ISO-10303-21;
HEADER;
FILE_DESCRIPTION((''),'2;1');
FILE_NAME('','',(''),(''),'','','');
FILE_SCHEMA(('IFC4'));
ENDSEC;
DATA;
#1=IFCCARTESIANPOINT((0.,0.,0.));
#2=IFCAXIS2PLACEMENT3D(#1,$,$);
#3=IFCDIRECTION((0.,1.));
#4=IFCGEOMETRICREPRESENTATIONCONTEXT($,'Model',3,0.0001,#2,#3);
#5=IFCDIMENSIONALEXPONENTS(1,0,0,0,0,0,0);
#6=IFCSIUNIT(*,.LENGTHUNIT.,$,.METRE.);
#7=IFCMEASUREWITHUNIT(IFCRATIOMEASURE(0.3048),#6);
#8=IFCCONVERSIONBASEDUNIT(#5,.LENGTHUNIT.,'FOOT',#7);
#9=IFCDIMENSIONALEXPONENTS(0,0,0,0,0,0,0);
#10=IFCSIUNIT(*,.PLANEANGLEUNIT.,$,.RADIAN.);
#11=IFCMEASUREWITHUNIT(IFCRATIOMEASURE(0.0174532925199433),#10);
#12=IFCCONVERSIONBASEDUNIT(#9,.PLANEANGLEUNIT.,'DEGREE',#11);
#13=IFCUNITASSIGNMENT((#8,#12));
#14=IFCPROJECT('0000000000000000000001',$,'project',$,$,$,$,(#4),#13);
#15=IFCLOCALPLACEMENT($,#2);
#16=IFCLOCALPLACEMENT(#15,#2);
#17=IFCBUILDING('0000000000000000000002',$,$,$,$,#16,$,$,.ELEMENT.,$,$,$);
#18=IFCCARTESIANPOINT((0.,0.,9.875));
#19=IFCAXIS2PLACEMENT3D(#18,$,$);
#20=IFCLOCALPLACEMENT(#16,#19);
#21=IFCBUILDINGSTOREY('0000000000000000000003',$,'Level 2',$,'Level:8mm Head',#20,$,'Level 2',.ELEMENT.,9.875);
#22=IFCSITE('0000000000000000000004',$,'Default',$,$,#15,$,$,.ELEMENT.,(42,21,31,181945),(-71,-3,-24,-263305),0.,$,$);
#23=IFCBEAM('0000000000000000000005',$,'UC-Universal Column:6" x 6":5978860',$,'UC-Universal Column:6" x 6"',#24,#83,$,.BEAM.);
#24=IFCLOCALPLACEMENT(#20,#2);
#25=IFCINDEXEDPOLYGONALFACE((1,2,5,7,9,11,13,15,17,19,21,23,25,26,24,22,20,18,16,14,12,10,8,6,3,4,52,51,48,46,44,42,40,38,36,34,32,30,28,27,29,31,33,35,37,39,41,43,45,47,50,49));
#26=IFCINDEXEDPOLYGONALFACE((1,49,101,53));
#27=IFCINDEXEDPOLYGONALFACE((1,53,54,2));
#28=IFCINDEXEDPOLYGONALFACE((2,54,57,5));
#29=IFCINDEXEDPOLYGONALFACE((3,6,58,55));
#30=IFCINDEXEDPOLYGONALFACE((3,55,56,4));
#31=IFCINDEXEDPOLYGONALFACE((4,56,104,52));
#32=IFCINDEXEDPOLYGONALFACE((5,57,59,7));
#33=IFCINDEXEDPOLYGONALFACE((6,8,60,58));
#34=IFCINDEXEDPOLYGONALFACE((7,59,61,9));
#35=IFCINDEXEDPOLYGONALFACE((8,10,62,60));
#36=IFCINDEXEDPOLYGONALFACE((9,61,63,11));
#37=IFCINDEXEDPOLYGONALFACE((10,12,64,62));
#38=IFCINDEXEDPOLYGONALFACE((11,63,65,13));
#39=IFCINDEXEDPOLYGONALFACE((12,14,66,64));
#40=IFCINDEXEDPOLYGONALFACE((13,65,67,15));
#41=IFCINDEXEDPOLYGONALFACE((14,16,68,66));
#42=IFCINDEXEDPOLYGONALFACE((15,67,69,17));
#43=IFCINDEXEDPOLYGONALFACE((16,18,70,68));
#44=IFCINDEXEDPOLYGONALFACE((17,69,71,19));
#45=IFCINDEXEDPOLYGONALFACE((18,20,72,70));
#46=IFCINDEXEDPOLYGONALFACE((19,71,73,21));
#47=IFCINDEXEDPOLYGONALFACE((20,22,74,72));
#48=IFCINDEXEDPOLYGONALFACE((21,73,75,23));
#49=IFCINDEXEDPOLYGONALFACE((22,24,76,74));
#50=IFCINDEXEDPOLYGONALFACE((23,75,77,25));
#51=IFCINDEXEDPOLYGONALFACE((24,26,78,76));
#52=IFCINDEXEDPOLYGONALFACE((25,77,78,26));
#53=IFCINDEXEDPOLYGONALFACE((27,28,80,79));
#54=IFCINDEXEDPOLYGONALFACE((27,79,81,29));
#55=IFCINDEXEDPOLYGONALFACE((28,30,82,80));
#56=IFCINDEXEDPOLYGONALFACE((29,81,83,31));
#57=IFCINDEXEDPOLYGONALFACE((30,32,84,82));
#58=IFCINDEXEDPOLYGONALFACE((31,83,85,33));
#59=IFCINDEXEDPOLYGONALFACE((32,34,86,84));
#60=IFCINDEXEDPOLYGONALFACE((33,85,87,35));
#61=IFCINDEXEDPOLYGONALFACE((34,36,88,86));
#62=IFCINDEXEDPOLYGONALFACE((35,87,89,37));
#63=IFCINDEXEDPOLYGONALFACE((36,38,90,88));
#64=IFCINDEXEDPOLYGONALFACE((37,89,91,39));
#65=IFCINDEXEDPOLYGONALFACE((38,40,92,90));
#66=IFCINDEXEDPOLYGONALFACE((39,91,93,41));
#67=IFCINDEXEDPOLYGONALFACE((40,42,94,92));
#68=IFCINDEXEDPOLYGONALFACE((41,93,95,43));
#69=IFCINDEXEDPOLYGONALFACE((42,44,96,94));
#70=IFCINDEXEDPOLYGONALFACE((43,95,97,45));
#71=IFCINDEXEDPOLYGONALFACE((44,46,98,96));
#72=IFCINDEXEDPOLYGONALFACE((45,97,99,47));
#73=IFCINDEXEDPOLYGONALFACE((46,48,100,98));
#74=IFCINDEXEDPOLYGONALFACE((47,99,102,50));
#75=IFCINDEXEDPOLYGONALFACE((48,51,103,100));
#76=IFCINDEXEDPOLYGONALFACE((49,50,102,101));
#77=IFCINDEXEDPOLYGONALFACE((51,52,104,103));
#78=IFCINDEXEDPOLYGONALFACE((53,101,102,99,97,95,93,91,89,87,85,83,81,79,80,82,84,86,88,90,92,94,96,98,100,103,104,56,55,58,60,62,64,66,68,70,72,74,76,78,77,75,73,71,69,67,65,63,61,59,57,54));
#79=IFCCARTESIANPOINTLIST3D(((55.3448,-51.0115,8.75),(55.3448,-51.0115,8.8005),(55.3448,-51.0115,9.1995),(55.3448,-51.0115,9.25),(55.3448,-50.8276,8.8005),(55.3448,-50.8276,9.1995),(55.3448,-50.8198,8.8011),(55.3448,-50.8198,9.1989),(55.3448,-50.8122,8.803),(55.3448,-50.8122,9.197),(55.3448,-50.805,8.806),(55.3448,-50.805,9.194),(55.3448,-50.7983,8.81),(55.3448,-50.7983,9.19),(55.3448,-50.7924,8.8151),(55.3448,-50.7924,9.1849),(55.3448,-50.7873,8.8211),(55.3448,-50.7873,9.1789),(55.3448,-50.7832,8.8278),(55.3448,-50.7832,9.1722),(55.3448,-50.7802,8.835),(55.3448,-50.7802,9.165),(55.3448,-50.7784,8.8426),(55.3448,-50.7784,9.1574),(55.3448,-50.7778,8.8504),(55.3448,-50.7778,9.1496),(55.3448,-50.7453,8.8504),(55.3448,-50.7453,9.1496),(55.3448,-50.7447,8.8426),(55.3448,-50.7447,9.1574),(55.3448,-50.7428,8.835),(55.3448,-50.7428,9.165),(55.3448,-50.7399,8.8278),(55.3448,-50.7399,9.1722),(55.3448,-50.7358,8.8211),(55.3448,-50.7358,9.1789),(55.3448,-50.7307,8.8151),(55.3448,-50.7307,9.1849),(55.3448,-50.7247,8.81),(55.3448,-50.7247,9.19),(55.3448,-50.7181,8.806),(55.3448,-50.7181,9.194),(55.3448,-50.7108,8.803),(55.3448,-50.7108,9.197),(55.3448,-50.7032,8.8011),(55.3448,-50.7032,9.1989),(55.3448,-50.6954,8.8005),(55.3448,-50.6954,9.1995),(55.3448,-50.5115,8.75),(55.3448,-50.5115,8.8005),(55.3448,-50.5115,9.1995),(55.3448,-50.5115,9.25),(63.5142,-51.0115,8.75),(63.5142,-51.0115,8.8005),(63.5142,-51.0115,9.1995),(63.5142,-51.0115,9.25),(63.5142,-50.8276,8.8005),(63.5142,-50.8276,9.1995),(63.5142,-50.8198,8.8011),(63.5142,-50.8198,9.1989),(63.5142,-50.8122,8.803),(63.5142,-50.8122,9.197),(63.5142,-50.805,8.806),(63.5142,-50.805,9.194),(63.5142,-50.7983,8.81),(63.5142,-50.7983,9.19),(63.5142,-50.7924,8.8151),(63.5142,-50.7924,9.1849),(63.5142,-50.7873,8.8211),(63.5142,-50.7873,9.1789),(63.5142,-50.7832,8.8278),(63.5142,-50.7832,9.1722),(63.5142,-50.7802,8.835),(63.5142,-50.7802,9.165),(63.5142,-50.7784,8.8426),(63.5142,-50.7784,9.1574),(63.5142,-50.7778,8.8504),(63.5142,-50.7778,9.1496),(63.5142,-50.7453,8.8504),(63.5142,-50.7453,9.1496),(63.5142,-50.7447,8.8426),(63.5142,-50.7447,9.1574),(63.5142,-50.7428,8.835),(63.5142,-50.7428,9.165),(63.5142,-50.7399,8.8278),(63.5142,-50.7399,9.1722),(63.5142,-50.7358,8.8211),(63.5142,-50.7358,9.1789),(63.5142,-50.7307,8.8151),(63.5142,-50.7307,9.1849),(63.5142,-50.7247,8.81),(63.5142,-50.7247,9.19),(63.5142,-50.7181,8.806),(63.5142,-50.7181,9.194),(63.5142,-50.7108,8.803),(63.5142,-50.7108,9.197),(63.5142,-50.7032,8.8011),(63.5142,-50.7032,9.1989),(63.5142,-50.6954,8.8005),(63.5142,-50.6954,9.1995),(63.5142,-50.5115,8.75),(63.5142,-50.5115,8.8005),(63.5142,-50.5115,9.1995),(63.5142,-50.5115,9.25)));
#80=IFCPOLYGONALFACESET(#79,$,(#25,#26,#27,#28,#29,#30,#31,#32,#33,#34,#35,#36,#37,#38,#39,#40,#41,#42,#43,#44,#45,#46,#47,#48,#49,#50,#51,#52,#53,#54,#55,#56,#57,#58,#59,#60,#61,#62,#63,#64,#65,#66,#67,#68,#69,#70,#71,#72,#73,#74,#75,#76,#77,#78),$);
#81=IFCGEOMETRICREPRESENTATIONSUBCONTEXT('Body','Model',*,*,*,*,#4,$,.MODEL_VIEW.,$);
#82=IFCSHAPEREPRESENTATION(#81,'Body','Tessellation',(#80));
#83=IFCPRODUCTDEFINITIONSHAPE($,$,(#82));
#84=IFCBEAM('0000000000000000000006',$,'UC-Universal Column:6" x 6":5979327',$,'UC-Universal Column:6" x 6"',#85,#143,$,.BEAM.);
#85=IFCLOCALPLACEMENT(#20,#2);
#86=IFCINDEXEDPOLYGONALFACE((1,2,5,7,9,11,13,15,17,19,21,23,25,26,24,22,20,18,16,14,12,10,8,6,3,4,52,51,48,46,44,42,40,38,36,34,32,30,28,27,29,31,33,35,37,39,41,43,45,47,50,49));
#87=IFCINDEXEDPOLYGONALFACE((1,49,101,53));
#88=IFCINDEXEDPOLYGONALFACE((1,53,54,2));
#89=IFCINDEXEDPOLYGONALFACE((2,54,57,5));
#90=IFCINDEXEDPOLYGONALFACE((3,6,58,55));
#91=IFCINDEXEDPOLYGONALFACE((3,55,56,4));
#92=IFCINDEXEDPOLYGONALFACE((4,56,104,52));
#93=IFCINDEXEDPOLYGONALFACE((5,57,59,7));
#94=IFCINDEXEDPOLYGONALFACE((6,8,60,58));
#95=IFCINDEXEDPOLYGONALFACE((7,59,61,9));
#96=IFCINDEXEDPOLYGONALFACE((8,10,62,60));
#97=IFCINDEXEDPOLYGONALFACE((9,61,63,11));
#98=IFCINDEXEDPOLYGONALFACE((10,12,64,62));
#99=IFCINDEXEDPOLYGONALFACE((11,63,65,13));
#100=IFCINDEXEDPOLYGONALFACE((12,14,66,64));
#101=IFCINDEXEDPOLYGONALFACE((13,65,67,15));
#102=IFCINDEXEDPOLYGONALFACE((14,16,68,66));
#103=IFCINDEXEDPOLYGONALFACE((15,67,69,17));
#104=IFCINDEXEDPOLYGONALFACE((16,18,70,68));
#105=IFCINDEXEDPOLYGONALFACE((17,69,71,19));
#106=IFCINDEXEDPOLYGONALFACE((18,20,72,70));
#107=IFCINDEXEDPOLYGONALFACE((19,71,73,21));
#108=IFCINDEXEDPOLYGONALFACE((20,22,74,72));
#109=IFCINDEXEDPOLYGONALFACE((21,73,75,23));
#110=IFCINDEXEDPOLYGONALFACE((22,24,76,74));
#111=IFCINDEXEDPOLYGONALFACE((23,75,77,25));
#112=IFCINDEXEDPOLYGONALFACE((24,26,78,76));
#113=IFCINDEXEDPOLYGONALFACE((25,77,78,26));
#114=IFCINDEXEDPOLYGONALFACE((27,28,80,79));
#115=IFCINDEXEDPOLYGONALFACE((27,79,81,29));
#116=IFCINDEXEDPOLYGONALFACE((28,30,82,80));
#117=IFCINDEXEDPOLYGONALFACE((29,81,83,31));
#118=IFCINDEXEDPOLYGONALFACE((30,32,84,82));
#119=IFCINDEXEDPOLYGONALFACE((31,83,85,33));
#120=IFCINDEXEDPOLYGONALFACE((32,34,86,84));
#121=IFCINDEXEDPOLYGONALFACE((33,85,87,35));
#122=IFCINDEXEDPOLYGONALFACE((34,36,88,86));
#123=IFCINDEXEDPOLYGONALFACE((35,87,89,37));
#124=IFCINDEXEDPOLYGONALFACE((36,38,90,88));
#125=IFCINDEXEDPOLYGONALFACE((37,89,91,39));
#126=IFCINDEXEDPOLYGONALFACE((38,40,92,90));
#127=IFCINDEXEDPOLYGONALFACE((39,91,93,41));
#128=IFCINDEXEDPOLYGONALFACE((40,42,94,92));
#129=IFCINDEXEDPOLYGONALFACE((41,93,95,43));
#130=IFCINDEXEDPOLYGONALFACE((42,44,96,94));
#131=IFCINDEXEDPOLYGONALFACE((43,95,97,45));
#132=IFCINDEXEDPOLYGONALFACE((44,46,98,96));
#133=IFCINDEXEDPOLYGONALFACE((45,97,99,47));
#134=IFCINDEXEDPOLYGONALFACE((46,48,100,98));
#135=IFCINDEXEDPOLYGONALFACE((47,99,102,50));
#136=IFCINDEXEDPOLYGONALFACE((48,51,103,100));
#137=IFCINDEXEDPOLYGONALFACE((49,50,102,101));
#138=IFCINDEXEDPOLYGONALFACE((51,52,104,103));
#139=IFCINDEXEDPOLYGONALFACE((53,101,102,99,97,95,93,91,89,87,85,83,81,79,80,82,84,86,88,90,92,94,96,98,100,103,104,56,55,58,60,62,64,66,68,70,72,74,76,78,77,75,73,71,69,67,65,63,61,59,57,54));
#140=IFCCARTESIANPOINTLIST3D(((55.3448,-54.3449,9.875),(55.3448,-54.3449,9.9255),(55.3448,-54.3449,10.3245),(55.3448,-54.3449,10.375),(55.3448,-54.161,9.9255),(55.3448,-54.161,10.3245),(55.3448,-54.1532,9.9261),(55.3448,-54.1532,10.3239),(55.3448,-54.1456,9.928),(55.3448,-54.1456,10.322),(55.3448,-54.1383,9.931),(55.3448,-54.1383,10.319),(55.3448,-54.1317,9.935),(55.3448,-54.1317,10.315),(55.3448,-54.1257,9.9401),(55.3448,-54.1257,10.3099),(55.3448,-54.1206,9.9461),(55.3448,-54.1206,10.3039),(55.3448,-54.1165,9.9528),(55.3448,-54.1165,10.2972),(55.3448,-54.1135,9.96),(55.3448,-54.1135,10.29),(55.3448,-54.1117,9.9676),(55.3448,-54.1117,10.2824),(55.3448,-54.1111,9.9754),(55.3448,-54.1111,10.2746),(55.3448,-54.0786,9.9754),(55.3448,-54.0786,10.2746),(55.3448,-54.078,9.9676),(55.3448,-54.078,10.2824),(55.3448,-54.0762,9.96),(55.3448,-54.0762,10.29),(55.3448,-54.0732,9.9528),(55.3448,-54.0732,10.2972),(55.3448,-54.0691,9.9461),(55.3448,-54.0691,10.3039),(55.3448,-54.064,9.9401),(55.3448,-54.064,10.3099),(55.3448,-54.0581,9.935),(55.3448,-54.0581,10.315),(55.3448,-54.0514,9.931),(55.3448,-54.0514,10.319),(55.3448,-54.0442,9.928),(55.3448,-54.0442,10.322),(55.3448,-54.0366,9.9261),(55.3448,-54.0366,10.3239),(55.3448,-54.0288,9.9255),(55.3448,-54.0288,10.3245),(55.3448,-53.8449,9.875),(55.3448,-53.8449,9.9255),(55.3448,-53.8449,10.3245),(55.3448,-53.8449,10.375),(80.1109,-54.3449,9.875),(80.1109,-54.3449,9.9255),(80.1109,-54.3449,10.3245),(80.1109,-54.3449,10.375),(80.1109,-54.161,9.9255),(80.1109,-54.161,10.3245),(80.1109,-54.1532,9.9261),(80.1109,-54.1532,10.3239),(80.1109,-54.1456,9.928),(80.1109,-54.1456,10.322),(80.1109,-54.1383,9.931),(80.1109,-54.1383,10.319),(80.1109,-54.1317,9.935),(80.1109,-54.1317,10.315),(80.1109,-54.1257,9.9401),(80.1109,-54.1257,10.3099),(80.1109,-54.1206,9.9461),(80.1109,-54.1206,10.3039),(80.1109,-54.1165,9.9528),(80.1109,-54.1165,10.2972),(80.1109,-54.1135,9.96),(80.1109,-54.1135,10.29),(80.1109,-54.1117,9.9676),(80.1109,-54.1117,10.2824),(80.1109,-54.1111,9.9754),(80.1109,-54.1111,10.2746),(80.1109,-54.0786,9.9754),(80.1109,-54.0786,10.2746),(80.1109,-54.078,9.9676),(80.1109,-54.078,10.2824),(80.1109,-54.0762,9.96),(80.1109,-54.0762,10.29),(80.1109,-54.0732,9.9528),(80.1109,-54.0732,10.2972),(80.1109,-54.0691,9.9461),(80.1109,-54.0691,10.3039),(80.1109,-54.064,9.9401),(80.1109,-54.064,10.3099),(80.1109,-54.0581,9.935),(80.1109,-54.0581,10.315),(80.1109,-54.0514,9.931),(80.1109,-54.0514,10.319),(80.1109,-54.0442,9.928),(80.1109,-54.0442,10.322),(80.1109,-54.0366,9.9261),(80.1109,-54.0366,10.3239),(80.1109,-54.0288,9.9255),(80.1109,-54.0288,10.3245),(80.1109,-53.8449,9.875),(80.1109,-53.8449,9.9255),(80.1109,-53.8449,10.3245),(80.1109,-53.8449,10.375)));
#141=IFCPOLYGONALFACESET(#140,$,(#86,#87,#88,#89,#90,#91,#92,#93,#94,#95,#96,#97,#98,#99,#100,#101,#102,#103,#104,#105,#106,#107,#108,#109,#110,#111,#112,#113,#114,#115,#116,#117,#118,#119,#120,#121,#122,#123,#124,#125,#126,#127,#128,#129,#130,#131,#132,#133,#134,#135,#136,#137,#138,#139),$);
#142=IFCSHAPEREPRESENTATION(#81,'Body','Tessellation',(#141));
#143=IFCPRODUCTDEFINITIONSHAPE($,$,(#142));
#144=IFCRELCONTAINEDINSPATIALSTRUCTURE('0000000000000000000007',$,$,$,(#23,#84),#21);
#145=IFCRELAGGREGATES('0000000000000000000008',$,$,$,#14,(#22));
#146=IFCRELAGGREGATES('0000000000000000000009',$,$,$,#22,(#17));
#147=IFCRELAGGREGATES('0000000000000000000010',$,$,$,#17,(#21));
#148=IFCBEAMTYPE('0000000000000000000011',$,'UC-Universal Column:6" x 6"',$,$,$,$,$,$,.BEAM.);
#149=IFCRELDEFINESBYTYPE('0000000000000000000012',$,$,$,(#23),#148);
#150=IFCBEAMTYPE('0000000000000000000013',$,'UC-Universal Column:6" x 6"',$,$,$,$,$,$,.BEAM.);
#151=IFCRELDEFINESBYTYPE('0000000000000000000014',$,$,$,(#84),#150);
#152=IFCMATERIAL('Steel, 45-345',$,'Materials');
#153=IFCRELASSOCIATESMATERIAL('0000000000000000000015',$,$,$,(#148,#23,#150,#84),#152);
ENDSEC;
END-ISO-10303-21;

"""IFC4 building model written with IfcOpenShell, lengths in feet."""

from ifc_helpers import new_model, entity, si_unit, converted_unit, direction, frame, origin, place, context, subcontext, project, spatial, indexed_curve, outline, extrude, source, transform, mapped, material, type_object, type_shapes, element, save


model = new_model("IFC4")

# Units and contexts
model_context = context("Model", 3, precision=0.0001, world=origin(), true_north=direction((0.0, 1.0)))
body_context = subcontext(model_context, "Body", "Model", "MODEL_VIEW")
ifc_project = project(units=[converted_unit("LENGTHUNIT", "FOOT", entity("IfcRatioMeasure", 0.3048), si_unit("LENGTHUNIT", "METRE"), dimensions=[1, 0, 0, 0, 0, 0, 0]), converted_unit("PLANEANGLEUNIT", "DEGREE", entity("IfcRatioMeasure", 0.0174532925199433), si_unit("PLANEANGLEUNIT", "RADIAN"), dimensions=[0, 0, 0, 0, 0, 0, 0])], contexts=[model_context])

# Site, building, storey
site_placement = place(None, origin())
site = spatial("IfcSite", under=ifc_project, at=site_placement, Name="Default", CompositionType="ELEMENT", RefLatitude=(42, 21, 31, 181945), RefLongitude=(-71, -3, -24, -263305), RefElevation=0.0)
building_placement = place(site_placement, origin())
building = spatial("IfcBuilding", under=site, at=building_placement, CompositionType="ELEMENT")
storey_placement = place(building_placement, frame((0.0, 0.0, 9.875)))
storey = spatial("IfcBuildingStorey", under=building, at=storey_placement, Name="Level 2", ObjectType="Level:8mm Head", LongName="Level 2", CompositionType="ELEMENT", Elevation=9.875)

# Beams
ifc_material_1 = material(Name="Steel, 45-345", Category="Materials")
beam_type_1 = type_object("IfcBeamType", Name="UC-Universal Column:6\" x 6\"", PredefinedType="BEAM", material=ifc_material_1)
shared_shape_1 = source(origin(), body_context, "Body", "SweptSolid", [
    extrude(outline(indexed_curve([(-0.25, -0.25), (-0.1995, -0.25), (-0.1995, -0.0661), (-0.1989, -0.0583), (-0.197, -0.0507), (-0.194, -0.0435), (-0.19, -0.0368), (-0.1849, -0.0308), (-0.1789, -0.0258), (-0.1722, -0.0217), (-0.165, -0.0187), (-0.1574, -0.0169), (-0.1496, -0.0162), (0.1496, -0.0162), (0.1574, -0.0169), (0.165, -0.0187), (0.1722, -0.0217), (0.1789, -0.0258), (0.1849, -0.0308), (0.19, -0.0368), (0.194, -0.0435), (0.197, -0.0507), (0.1989, -0.0583), (0.1995, -0.0661), (0.1995, -0.25), (0.25, -0.25), (0.25, 0.25), (0.1995, 0.25), (0.1995, 0.0661), (0.1989, 0.0583), (0.197, 0.0507), (0.194, 0.0435), (0.19, 0.0368), (0.1849, 0.0308), (0.1789, 0.0258), (0.1722, 0.0217), (0.165, 0.0187), (0.1574, 0.0169), (0.1496, 0.0162), (-0.1496, 0.0162), (-0.1574, 0.0169), (-0.165, 0.0187), (-0.1722, 0.0217), (-0.1789, 0.0258), (-0.1849, 0.0308), (-0.19, 0.0368), (-0.194, 0.0435), (-0.197, 0.0507), (-0.1989, 0.0583), (-0.1995, 0.0661), (-0.1995, 0.25), (-0.25, 0.25), (-0.25, -0.25)], self_intersect=False)), frame((-17.0237, 0.0, 0.0), z_axis=(1.0, 0.0, 0.0), x_axis=(0.0, 0.0, -1.0)), (0.0, 0.0, 1.0), 8.1694),
])
type_shapes(beam_type_1, [shared_shape_1])
beam_1_placement = place(storey_placement, frame((72.3685, -50.7615, 9.0)))
element("IfcBeam", 1, at=beam_1_placement, inside=storey, type_object=beam_type_1, material=ifc_material_1, Name="UC-Universal Column:6\" x 6\":5978860", ObjectType="UC-Universal Column:6\" x 6\"", PredefinedType="BEAM", context=body_context, shape_type="MappedRepresentation", body=[
    mapped(shared_shape_1, transform((0.0, 0.0, 0.0), scale=1.0)),
])
beam_type_2 = type_object("IfcBeamType", Name="UC-Universal Column:6\" x 6\"", PredefinedType="BEAM", material=ifc_material_1)
shared_shape_2 = source(origin(), body_context, "Body", "SweptSolid", [
    extrude(outline(indexed_curve([(-0.25, -0.25), (-0.1995, -0.25), (-0.1995, -0.0661), (-0.1989, -0.0583), (-0.197, -0.0507), (-0.194, -0.0435), (-0.19, -0.0368), (-0.1849, -0.0308), (-0.1789, -0.0258), (-0.1722, -0.0217), (-0.165, -0.0187), (-0.1574, -0.0169), (-0.1496, -0.0162), (0.1496, -0.0162), (0.1574, -0.0169), (0.165, -0.0187), (0.1722, -0.0217), (0.1789, -0.0258), (0.1849, -0.0308), (0.19, -0.0368), (0.194, -0.0435), (0.197, -0.0507), (0.1989, -0.0583), (0.1995, -0.0661), (0.1995, -0.25), (0.25, -0.25), (0.25, 0.25), (0.1995, 0.25), (0.1995, 0.0661), (0.1989, 0.0583), (0.197, 0.0507), (0.194, 0.0435), (0.19, 0.0368), (0.1849, 0.0308), (0.1789, 0.0258), (0.1722, 0.0217), (0.165, 0.0187), (0.1574, 0.0169), (0.1496, 0.0162), (-0.1496, 0.0162), (-0.1574, 0.0169), (-0.165, 0.0187), (-0.1722, 0.0217), (-0.1789, 0.0258), (-0.1849, 0.0308), (-0.19, 0.0368), (-0.194, 0.0435), (-0.197, 0.0507), (-0.1989, 0.0583), (-0.1995, 0.0661), (-0.1995, 0.25), (-0.25, 0.25), (-0.25, -0.25)], self_intersect=False)), frame((-17.0237, 0.0, 0.0), z_axis=(1.0, 0.0, 0.0), x_axis=(0.0, 0.0, -1.0)), (0.0, 0.0, 1.0), 24.7661),
])
type_shapes(beam_type_2, [shared_shape_2])
beam_2_placement = place(storey_placement, frame((72.3685, -54.0949, 10.125)))
element("IfcBeam", 2, at=beam_2_placement, inside=storey, type_object=beam_type_2, material=ifc_material_1, Name="UC-Universal Column:6\" x 6\":5979327", ObjectType="UC-Universal Column:6\" x 6\"", PredefinedType="BEAM", context=body_context, shape_type="MappedRepresentation", body=[
    mapped(shared_shape_2, transform((0.0, 0.0, 0.0), scale=1.0)),
])

save(model, "model.ifc")
